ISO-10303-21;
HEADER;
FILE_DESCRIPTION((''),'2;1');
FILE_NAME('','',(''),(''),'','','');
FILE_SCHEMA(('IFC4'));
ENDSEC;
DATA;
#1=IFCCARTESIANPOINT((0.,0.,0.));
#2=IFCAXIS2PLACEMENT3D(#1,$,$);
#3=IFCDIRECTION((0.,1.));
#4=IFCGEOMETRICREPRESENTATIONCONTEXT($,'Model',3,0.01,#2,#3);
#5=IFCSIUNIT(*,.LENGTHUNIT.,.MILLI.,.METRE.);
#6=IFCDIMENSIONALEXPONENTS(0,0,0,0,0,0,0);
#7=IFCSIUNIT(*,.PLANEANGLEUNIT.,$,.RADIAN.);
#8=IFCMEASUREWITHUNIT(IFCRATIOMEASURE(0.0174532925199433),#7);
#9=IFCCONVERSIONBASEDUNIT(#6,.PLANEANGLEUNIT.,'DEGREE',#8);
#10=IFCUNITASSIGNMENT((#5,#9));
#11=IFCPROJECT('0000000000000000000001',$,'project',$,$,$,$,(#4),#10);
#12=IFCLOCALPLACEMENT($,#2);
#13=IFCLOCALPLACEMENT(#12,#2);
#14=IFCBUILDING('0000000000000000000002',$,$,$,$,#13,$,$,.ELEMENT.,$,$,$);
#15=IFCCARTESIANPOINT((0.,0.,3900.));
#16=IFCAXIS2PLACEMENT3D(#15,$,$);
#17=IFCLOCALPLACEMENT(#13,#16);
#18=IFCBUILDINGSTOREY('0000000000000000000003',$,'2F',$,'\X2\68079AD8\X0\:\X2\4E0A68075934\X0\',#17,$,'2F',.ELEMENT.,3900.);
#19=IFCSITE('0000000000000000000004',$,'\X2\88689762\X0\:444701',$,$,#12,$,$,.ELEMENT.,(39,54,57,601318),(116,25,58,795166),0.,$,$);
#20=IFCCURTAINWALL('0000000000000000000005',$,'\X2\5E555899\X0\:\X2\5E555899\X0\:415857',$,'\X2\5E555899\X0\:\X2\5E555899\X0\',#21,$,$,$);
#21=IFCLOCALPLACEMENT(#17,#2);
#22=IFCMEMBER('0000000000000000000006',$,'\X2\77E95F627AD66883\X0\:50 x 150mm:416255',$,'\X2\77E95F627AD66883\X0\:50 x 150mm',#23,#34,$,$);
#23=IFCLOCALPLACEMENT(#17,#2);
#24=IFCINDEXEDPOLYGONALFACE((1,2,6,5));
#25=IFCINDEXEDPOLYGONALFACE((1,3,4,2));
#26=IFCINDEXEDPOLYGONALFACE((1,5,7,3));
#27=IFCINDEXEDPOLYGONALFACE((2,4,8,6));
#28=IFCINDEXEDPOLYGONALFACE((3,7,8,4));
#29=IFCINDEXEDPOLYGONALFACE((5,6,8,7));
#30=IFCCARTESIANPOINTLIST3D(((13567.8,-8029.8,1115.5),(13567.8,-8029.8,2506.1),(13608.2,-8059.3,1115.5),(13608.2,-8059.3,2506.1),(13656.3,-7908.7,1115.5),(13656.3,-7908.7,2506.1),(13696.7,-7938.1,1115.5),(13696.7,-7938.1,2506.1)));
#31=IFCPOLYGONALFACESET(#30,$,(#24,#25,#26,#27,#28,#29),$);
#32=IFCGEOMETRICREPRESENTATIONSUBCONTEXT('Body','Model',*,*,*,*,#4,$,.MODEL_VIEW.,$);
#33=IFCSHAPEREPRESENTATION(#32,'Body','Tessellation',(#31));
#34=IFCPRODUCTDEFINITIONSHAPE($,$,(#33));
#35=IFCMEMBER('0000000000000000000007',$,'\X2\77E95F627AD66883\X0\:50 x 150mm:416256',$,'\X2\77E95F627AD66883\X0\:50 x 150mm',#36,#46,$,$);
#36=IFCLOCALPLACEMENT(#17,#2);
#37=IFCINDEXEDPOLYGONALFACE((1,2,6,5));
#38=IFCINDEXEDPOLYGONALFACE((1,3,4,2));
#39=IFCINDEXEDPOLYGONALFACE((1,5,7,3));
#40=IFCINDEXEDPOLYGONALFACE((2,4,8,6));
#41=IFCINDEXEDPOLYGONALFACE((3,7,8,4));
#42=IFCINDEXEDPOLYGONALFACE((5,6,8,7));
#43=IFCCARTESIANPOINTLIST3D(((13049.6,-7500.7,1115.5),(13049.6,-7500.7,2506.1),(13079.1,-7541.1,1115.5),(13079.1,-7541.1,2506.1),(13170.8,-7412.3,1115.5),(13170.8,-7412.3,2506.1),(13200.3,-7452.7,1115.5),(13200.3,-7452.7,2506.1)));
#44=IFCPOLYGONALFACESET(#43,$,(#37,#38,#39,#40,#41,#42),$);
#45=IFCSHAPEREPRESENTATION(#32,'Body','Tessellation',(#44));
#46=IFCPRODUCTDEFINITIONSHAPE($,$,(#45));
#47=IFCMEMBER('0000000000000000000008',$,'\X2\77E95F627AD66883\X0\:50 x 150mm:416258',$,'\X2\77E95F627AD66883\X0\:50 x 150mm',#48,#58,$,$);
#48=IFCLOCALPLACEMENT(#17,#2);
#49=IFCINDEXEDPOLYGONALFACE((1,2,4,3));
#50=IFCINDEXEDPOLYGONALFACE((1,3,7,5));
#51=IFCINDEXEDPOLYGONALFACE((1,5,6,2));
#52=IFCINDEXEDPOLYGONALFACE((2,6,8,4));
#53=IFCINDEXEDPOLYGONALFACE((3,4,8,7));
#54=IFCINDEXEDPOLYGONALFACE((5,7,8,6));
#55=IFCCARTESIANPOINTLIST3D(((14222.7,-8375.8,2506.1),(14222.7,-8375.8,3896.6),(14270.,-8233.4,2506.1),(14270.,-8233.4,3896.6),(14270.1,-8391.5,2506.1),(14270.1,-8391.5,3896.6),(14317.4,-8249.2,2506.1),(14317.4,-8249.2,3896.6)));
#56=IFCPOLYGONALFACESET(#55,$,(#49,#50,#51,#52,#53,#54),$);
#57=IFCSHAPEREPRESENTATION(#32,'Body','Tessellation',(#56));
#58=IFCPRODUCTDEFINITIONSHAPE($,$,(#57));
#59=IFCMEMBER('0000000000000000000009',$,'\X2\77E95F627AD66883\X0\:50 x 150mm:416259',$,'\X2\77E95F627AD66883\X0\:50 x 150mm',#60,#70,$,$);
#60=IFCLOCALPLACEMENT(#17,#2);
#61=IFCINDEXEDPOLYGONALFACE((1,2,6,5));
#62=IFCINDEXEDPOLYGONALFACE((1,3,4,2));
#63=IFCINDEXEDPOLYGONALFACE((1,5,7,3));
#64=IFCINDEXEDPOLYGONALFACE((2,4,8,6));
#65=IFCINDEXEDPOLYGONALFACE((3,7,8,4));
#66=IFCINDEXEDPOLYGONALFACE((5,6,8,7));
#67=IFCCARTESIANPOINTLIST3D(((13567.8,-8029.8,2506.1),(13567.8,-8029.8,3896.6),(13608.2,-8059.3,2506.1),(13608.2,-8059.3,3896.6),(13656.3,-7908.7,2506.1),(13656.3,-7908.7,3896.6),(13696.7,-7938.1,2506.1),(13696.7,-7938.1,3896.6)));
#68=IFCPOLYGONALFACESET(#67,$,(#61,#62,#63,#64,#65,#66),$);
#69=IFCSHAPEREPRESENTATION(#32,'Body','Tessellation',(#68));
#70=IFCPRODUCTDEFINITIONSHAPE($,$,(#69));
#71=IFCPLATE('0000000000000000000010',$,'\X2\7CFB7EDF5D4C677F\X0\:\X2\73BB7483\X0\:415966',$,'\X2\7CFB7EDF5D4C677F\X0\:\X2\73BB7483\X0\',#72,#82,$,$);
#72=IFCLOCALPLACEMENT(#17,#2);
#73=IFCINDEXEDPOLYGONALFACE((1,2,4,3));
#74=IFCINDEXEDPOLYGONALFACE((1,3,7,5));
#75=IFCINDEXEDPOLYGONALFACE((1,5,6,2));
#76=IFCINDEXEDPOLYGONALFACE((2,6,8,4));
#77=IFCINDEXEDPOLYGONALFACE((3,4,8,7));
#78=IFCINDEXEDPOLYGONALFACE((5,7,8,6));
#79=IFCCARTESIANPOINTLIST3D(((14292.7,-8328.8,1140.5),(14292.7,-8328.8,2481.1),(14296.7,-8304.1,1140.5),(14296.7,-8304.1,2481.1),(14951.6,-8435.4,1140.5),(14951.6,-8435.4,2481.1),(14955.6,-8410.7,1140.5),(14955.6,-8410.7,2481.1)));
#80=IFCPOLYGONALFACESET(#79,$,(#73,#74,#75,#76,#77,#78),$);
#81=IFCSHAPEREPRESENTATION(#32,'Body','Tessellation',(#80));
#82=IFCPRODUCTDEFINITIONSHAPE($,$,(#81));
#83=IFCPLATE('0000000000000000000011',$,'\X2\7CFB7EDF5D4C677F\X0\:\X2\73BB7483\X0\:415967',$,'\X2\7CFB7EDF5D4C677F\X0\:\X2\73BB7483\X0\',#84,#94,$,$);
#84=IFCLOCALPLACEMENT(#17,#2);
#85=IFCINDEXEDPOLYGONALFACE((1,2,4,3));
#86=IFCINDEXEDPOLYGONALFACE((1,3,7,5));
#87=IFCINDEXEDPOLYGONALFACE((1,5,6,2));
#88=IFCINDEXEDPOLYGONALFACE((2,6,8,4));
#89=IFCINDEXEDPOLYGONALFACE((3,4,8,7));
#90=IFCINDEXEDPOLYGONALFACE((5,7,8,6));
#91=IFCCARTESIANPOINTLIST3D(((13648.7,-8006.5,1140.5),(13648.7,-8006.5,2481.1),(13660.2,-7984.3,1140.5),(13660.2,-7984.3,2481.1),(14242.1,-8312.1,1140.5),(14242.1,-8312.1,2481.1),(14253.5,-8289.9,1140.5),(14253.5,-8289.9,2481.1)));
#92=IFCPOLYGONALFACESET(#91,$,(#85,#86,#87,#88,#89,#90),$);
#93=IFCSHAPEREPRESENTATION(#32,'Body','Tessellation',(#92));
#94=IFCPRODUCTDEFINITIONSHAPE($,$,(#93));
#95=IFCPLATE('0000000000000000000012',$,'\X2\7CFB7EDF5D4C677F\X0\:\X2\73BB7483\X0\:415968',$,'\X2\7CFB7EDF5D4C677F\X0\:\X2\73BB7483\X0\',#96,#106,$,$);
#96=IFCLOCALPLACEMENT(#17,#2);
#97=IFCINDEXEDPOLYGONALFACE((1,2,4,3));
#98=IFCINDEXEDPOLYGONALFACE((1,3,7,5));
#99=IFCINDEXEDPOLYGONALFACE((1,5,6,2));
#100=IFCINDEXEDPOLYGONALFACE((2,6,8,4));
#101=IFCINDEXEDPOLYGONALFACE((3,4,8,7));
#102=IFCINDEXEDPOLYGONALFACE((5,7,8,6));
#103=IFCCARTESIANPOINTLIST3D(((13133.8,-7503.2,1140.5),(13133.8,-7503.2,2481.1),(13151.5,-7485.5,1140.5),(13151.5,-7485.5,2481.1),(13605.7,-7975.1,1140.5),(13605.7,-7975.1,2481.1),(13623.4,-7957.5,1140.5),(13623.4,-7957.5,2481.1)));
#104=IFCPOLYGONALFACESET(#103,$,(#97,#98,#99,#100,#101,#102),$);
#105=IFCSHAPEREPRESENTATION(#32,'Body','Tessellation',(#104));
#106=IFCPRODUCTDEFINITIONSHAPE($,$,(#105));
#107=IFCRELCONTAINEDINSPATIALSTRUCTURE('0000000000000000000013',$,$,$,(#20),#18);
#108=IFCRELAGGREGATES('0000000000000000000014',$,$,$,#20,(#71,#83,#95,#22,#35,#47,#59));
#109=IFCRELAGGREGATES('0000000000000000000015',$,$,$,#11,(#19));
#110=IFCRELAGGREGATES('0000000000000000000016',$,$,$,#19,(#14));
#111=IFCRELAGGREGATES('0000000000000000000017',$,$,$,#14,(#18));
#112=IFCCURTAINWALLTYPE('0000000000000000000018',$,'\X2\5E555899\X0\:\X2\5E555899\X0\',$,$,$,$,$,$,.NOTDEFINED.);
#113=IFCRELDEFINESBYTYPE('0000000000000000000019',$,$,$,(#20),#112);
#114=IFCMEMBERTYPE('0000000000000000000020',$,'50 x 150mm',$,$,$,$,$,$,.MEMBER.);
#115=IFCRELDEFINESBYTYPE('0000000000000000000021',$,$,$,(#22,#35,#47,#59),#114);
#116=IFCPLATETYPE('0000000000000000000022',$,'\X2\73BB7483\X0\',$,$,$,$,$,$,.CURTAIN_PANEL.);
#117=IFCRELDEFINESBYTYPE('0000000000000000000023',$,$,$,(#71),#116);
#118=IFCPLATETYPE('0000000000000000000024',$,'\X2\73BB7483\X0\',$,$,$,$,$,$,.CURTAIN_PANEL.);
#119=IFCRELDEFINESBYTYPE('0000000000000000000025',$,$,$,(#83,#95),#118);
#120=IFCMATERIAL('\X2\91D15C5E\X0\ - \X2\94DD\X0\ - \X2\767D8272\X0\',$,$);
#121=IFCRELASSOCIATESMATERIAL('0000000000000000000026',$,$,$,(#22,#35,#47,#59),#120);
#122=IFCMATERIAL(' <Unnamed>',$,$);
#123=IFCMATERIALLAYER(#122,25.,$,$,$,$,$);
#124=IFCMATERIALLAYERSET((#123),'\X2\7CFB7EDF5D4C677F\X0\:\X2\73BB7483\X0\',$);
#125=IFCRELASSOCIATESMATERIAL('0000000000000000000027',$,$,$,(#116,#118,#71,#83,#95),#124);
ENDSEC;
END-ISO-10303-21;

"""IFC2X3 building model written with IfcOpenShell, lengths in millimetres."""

from ifc_helpers import new_model, entity, si_unit, converted_unit, direction, frame, frame_2d, origin, origin_2d_with_axis, place, context, subcontext, project, spatial, rectangle, extrude, source, transform, mapped, material, layer, layer_set, layer_usage, type_object, type_shapes, element, aggregate, save


model = new_model("IFC2X3")

# Units and contexts
model_context = context("Model", 3, precision=0.01, world=origin(), true_north=direction((0.0, 1.0)))
body_context = subcontext(model_context, "Body", "Model", "MODEL_VIEW")
ifc_project = project(units=[si_unit("LENGTHUNIT", "METRE", prefix="MILLI"), converted_unit("PLANEANGLEUNIT", "DEGREE", entity("IfcRatioMeasure", 0.0174532925199433), si_unit("PLANEANGLEUNIT", "RADIAN"), dimensions=[0, 0, 0, 0, 0, 0, 0])], contexts=[model_context])

# Site, building, storey
site_placement = place(None, origin())
site = spatial("IfcSite", under=ifc_project, at=site_placement, Name="表面:444701", CompositionType="ELEMENT", RefLatitude=(39, 54, 57, 601318), RefLongitude=(116, 25, 58, 795166), RefElevation=0.0)
building_placement = place(site_placement, origin())
building = spatial("IfcBuilding", under=site, at=building_placement, CompositionType="ELEMENT")
storey_placement = place(building_placement, frame((0.0, 0.0, 3900.0)))
storey = spatial("IfcBuildingStorey", under=building, at=storey_placement, Name="2F", ObjectType="标高:上标头", LongName="2F", CompositionType="ELEMENT", Elevation=3900.0)

# Curtain wall
curtain_wall_type = type_object("IfcCurtainWallType", Name="幕墙:幕墙", PredefinedType="NOTDEFINED")
curtain_wall_1_placement = place(storey_placement, frame((0.0, 0.0, -3900.0)))
curtain_wall_1 = element("IfcCurtainWall", 1, at=curtain_wall_1_placement, inside=storey, type_object=curtain_wall_type, Name="幕墙:幕墙:415857", ObjectType="幕墙:幕墙")
ifc_material_1 = material(Name="金属 - 铝 - 白色")

# Members
member_type_1 = type_object("IfcMemberType", Name="50 x 150mm", PredefinedType="MEMBER")
shared_shape_1 = source(origin(), body_context, "Body", "SweptSolid", [
    extrude(rectangle(XDim=150.0, YDim=50.0, at=origin_2d_with_axis()), frame((0.0, 0.0, -1390.5), z_axis=(0.0, 0.0, 1.0), x_axis=(0.0, -1.0, 0.0)), (0.0, 0.0, 1.0), 1390.5),
])
type_shapes(member_type_1, [shared_shape_1])
member_1_placement = place(storey_placement, frame((13632.2, -7984.0, 1115.5), z_axis=(0.0, 0.0, -1.0), x_axis=(-0.807735, 0.589546, 0.0)))
member_1 = element("IfcMember", 2, at=member_1_placement, type_object=member_type_1, material=ifc_material_1, Name="矩形竖梃:50 x 150mm:416255", ObjectType="矩形竖梃:50 x 150mm", context=body_context, shape_type="MappedRepresentation", body=[
    mapped(shared_shape_1, transform((0.0, 0.0, 0.0), scale=1.0)),
])
member_2_placement = place(storey_placement, frame((13125.0, -7476.7, 1115.5), z_axis=(0.0, 0.0, -1.0), x_axis=(-0.589546, 0.807735, 0.0)))
member_2 = element("IfcMember", 3, at=member_2_placement, type_object=member_type_1, material=ifc_material_1, Name="矩形竖梃:50 x 150mm:416256", ObjectType="矩形竖梃:50 x 150mm", context=body_context, shape_type="MappedRepresentation", body=[
    mapped(shared_shape_1, transform((0.0, 0.0, 0.0), scale=1.0)),
])
member_3_placement = place(storey_placement, frame((14270.0, -8312.5, 2506.1), z_axis=(0.0, 0.0, -1.0), x_axis=(-0.949018, 0.315223, 0.0)))
member_3 = element("IfcMember", 4, at=member_3_placement, type_object=member_type_1, material=ifc_material_1, Name="矩形竖梃:50 x 150mm:416258", ObjectType="矩形竖梃:50 x 150mm", context=body_context, shape_type="MappedRepresentation", body=[
    mapped(shared_shape_1, transform((0.0, 0.0, 0.0), scale=1.0)),
])
member_4_placement = place(storey_placement, frame((13632.2, -7984.0, 2506.1), z_axis=(0.0, 0.0, -1.0), x_axis=(-0.807735, 0.589546, 0.0)))
member_4 = element("IfcMember", 5, at=member_4_placement, type_object=member_type_1, material=ifc_material_1, Name="矩形竖梃:50 x 150mm:416259", ObjectType="矩形竖梃:50 x 150mm", context=body_context, shape_type="MappedRepresentation", body=[
    mapped(shared_shape_1, transform((0.0, 0.0, 0.0), scale=1.0)),
])

# Plates
ifc_material_2 = material(Name=" <Unnamed>")
ifc_layer = layer(ifc_material_2, 25.0)
ifc_layer_set = layer_set([ifc_layer], Name="系统嵌板:玻璃")
ifc_layer_usage_1 = layer_usage(ifc_layer_set, "AXIS3", "POSITIVE", 0.0)
plate_type_1 = type_object("IfcPlateType", Name="玻璃", PredefinedType="CURTAIN_PANEL", material=ifc_layer_set)
shared_shape_2 = source(origin(), body_context, "Body", "SweptSolid", [
    extrude(rectangle(XDim=25.0, YDim=667.4, at=frame_2d((0.0, 0.0), x_axis=(1.0, 0.0))), frame((0.0, 0.0, 0.0), z_axis=(0.0, 0.0, 1.0), x_axis=(0.0, 1.0, 0.0)), (0.0, 0.0, 1.0), 1340.5),
])
type_shapes(plate_type_1, [shared_shape_2])
plate_1_placement = place(curtain_wall_1_placement, frame((14624.2, -8369.7, 5040.5), z_axis=(0.0, 0.0, 1.0), x_axis=(-0.987172, 0.15966, 0.0)))
plate_1 = element("IfcPlate", 6, at=plate_1_placement, type_object=plate_type_1, material=ifc_layer_usage_1, Name="系统嵌板:玻璃:415966", ObjectType="系统嵌板:玻璃", context=body_context, shape_type="MappedRepresentation", body=[
    mapped(shared_shape_2, transform((0.0, 0.0, 0.0), scale=1.0)),
])
ifc_layer_usage_2 = layer_usage(ifc_layer_set, "AXIS3", "POSITIVE", 0.0)
plate_type_2 = type_object("IfcPlateType", Name="玻璃", PredefinedType="CURTAIN_PANEL", material=ifc_layer_set)
shared_shape_3 = source(origin(), body_context, "Body", "SweptSolid", [
    extrude(rectangle(XDim=25.0, YDim=667.4, at=frame_2d((0.0, 0.0), x_axis=(1.0, 0.0))), frame((0.0, 0.0, 0.0), z_axis=(0.0, 0.0, 1.0), x_axis=(0.0, 1.0, 0.0)), (0.0, 0.0, 1.0), 1340.5),
])
type_shapes(plate_type_2, [shared_shape_3])
plate_2_placement = place(curtain_wall_1_placement, frame((13951.1, -8148.2, 5040.5), z_axis=(0.0, 0.0, 1.0), x_axis=(-0.889021, 0.457867, 0.0)))
plate_2 = element("IfcPlate", 7, at=plate_2_placement, type_object=plate_type_2, material=ifc_layer_usage_2, Name="系统嵌板:玻璃:415967", ObjectType="系统嵌板:玻璃", context=body_context, shape_type="MappedRepresentation", body=[
    mapped(shared_shape_3, transform((0.0, 0.0, 0.0), scale=1.0)),
])
ifc_layer_usage_3 = layer_usage(ifc_layer_set, "AXIS3", "POSITIVE", 0.0)
plate_3_placement = place(curtain_wall_1_placement, frame((13378.6, -7730.3, 5040.5), z_axis=(0.0, 0.0, 1.0), x_axis=(-0.707107, 0.707107, 0.0)))
plate_3 = element("IfcPlate", 8, at=plate_3_placement, type_object=plate_type_2, material=ifc_layer_usage_3, Name="系统嵌板:玻璃:415968", ObjectType="系统嵌板:玻璃", context=body_context, shape_type="MappedRepresentation", body=[
    mapped(shared_shape_3, transform((0.0, 0.0, 0.0), scale=1.0)),
])
aggregate(curtain_wall_1, [plate_1, plate_2, plate_3, member_1, member_2, member_3, member_4])

save(model, "model.ifc")
